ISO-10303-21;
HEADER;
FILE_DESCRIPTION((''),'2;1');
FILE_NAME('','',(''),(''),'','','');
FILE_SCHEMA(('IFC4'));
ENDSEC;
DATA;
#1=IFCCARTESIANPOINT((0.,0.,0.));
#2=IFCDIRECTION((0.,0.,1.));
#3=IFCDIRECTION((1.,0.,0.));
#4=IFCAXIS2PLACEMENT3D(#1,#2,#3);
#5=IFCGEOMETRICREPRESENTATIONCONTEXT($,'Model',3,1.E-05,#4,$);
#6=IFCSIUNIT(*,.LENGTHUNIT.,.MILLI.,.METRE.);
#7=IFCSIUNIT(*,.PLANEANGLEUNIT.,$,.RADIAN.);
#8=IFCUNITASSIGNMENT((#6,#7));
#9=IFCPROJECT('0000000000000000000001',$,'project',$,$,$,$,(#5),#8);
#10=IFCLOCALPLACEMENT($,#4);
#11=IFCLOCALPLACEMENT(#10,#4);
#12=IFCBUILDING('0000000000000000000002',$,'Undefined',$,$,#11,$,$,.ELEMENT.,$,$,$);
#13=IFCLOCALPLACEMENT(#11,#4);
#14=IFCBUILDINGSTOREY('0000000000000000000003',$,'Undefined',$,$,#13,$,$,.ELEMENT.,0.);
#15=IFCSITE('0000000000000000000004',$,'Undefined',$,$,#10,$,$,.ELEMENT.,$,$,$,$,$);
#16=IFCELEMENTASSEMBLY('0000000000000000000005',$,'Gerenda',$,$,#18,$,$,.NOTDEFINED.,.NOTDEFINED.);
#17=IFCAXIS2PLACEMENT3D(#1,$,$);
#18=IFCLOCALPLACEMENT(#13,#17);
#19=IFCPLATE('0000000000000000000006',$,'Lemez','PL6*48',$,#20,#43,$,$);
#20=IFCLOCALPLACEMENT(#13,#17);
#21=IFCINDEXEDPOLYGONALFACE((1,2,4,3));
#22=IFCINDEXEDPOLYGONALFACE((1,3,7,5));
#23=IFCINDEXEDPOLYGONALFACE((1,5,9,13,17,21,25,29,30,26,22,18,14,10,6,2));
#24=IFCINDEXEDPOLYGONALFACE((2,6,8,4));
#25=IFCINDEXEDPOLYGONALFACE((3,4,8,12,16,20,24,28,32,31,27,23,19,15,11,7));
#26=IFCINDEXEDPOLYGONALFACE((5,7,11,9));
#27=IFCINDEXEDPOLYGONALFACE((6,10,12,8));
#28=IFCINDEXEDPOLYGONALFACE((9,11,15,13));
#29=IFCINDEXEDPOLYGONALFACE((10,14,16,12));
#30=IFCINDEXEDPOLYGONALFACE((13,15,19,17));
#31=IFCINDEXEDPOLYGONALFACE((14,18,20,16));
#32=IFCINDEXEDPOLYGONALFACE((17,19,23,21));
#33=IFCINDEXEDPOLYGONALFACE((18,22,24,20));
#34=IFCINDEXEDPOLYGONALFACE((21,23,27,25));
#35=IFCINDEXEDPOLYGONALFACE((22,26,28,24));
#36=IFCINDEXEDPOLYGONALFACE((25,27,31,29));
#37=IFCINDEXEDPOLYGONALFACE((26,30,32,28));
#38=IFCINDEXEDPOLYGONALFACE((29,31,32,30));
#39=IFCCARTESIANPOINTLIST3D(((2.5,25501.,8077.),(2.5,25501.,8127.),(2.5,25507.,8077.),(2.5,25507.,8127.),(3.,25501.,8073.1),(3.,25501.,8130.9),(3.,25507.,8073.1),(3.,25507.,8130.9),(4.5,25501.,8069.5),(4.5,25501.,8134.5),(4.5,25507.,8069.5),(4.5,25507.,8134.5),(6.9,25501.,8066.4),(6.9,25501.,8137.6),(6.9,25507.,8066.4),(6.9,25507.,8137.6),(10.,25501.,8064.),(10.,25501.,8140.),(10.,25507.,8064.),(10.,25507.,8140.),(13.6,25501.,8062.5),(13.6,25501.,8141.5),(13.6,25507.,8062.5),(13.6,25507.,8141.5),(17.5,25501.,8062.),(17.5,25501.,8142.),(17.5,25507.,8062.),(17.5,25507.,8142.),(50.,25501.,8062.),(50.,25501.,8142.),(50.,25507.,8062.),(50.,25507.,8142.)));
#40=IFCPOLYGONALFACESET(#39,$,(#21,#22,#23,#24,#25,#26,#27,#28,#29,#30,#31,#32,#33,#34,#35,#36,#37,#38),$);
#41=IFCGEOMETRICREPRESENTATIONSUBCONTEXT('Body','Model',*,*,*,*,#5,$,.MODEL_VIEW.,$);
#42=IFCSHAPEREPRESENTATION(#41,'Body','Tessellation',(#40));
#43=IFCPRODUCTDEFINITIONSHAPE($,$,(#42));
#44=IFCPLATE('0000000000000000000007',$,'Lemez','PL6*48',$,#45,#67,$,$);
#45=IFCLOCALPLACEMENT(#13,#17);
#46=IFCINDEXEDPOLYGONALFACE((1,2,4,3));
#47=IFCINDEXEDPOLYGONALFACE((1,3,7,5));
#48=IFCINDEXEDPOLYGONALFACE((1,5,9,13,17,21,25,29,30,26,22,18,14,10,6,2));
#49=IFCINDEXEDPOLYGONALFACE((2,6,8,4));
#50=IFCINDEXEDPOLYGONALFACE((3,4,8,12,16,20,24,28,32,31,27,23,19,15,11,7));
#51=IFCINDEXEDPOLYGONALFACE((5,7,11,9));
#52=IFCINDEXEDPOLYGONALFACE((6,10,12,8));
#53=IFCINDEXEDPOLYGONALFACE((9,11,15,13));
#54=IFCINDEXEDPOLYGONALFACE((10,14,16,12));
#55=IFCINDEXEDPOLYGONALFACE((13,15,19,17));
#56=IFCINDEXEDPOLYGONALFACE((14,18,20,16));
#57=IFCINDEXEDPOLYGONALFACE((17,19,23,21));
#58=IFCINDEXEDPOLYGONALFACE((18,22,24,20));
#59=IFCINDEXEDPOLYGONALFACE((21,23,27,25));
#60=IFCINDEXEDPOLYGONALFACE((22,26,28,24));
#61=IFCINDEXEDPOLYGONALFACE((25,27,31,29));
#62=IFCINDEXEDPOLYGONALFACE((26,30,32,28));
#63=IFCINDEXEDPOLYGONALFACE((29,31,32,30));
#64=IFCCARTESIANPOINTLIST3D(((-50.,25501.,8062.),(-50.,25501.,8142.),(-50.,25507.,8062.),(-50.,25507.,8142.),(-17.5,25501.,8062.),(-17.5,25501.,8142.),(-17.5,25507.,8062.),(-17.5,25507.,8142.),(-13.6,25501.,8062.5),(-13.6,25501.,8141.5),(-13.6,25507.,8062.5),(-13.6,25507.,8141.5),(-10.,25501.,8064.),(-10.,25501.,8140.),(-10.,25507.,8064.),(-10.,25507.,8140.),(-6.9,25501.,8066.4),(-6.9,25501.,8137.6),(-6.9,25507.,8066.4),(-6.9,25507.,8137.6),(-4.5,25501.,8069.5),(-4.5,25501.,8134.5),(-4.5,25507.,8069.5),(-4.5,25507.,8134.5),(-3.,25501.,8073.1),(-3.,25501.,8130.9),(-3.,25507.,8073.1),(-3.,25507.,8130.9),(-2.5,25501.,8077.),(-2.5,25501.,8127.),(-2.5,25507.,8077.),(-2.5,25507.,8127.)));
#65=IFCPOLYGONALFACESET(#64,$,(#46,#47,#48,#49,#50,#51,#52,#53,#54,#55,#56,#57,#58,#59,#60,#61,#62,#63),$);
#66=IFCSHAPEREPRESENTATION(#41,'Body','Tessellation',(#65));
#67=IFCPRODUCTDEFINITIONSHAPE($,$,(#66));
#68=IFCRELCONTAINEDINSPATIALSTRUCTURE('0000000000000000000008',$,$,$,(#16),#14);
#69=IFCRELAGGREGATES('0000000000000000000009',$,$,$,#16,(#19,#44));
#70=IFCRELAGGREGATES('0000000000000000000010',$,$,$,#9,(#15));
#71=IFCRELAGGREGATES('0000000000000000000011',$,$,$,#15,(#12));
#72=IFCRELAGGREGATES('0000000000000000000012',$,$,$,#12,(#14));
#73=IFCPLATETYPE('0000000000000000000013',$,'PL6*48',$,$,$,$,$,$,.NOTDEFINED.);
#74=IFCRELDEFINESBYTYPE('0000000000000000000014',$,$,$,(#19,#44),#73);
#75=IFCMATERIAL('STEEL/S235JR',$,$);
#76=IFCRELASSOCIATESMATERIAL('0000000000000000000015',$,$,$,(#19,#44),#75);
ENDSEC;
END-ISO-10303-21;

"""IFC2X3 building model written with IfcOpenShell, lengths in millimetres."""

from ifc_helpers import new_model, si_unit, frame, frame_2d, origin_with_axes, place, context, subcontext, project, spatial, polyline, circle_curve, parameter, trimmed, segment, composite_curve, outline, extrude, material, type_object, element, aggregate, save


model = new_model("IFC2X3")

# Units and contexts
model_context = context("Model", 3, precision=1e-05, world=origin_with_axes())
body_context = subcontext(model_context, "Body", "Model", "MODEL_VIEW")
ifc_project = project(units=[si_unit("LENGTHUNIT", "METRE", prefix="MILLI"), si_unit("PLANEANGLEUNIT", "RADIAN")], contexts=[model_context])

# Site, building, storey
site_placement = place(None, origin_with_axes())
site = spatial("IfcSite", under=ifc_project, at=site_placement, Name="Undefined", CompositionType="ELEMENT")
building_placement = place(site_placement, origin_with_axes())
building = spatial("IfcBuilding", under=site, at=building_placement, Name="Undefined", CompositionType="ELEMENT")
storey_placement = place(building_placement, origin_with_axes())
storey = spatial("IfcBuildingStorey", under=building, at=storey_placement, Name="Undefined", CompositionType="ELEMENT", Elevation=0.0)

# Element assembly
ifc_material_1 = material(Name="STEEL/S235JR")
assembly_1_placement = place(storey_placement, origin_with_axes())
assembly_1 = element("IfcElementAssembly", 1, at=assembly_1_placement, inside=storey, Name="Gerenda", AssemblyPlace="NOTDEFINED", PredefinedType="NOTDEFINED")

# Plates
plate_type_1 = type_object("IfcPlateType", Name="PL6*48", PredefinedType="NOTDEFINED")
plate_1_placement = place(assembly_1_placement, frame((2.5, 25504.0, 8062.0), z_axis=(-0.000003, -1.0, 0.0), x_axis=(1.0, -0.000003, 0.0)))
plate_1 = element("IfcPlate", 2, at=plate_1_placement, type_object=plate_type_1, material=ifc_material_1, Name="Lemez", Description="PL6*48", context=body_context, shape_type="SweptSolid", body=[
    extrude(outline(composite_curve([segment(trimmed(circle_curve(frame_2d((15.0, 15.0), x_axis=(-1.0, 0.0)), 15.0), [parameter(0.0)], [parameter(1.570796)], True, "PARAMETER"), True, "CONTINUOUS"), segment(polyline([(15.0, 0.0), (47.5, 0.0), (47.5, 80.0), (15.0, 80.0)]), True, "CONTINUOUS"), segment(trimmed(circle_curve(frame_2d((15.0, 65.0), x_axis=(0.0, 1.0)), 15.0), [parameter(0.0)], [parameter(1.570796)], True, "PARAMETER"), True, "CONTINUOUS"), segment(polyline([(0.0, 65.0), (0.0, 15.0)]), True, "CONTINUOUS")], self_intersect=True)), frame((0.0, 0.0, -3.0), z_axis=(0.0, 0.0, 1.0), x_axis=(1.0, 0.0, 0.0)), (0.0, 0.0, 1.0), 6.0),
])
plate_2_placement = place(assembly_1_placement, frame((-2.5, 25504.0, 8062.0), z_axis=(0.000003, 1.0, 0.0), x_axis=(-1.0, 0.000003, 0.0)))
plate_2 = element("IfcPlate", 3, at=plate_2_placement, type_object=plate_type_1, material=ifc_material_1, Name="Lemez", Description="PL6*48", context=body_context, shape_type="SweptSolid", body=[
    extrude(outline(composite_curve([segment(trimmed(circle_curve(frame_2d((15.0, 15.0), x_axis=(-1.0, 0.0)), 15.0), [parameter(0.0)], [parameter(1.570796)], True, "PARAMETER"), True, "CONTINUOUS"), segment(polyline([(15.0, 0.0), (47.5, 0.0), (47.5, 80.0), (15.0, 80.0)]), True, "CONTINUOUS"), segment(trimmed(circle_curve(frame_2d((15.0, 65.0), x_axis=(0.0, 1.0)), 15.0), [parameter(0.0)], [parameter(1.570796)], True, "PARAMETER"), True, "CONTINUOUS"), segment(polyline([(0.0, 65.0), (0.0, 15.0)]), True, "CONTINUOUS")], self_intersect=True)), frame((0.0, 0.0, -3.0), z_axis=(0.0, 0.0, 1.0), x_axis=(1.0, 0.0, 0.0)), (0.0, 0.0, 1.0), 6.0),
])

aggregate(assembly_1, [plate_1, plate_2])

save(model, "model.ifc")
